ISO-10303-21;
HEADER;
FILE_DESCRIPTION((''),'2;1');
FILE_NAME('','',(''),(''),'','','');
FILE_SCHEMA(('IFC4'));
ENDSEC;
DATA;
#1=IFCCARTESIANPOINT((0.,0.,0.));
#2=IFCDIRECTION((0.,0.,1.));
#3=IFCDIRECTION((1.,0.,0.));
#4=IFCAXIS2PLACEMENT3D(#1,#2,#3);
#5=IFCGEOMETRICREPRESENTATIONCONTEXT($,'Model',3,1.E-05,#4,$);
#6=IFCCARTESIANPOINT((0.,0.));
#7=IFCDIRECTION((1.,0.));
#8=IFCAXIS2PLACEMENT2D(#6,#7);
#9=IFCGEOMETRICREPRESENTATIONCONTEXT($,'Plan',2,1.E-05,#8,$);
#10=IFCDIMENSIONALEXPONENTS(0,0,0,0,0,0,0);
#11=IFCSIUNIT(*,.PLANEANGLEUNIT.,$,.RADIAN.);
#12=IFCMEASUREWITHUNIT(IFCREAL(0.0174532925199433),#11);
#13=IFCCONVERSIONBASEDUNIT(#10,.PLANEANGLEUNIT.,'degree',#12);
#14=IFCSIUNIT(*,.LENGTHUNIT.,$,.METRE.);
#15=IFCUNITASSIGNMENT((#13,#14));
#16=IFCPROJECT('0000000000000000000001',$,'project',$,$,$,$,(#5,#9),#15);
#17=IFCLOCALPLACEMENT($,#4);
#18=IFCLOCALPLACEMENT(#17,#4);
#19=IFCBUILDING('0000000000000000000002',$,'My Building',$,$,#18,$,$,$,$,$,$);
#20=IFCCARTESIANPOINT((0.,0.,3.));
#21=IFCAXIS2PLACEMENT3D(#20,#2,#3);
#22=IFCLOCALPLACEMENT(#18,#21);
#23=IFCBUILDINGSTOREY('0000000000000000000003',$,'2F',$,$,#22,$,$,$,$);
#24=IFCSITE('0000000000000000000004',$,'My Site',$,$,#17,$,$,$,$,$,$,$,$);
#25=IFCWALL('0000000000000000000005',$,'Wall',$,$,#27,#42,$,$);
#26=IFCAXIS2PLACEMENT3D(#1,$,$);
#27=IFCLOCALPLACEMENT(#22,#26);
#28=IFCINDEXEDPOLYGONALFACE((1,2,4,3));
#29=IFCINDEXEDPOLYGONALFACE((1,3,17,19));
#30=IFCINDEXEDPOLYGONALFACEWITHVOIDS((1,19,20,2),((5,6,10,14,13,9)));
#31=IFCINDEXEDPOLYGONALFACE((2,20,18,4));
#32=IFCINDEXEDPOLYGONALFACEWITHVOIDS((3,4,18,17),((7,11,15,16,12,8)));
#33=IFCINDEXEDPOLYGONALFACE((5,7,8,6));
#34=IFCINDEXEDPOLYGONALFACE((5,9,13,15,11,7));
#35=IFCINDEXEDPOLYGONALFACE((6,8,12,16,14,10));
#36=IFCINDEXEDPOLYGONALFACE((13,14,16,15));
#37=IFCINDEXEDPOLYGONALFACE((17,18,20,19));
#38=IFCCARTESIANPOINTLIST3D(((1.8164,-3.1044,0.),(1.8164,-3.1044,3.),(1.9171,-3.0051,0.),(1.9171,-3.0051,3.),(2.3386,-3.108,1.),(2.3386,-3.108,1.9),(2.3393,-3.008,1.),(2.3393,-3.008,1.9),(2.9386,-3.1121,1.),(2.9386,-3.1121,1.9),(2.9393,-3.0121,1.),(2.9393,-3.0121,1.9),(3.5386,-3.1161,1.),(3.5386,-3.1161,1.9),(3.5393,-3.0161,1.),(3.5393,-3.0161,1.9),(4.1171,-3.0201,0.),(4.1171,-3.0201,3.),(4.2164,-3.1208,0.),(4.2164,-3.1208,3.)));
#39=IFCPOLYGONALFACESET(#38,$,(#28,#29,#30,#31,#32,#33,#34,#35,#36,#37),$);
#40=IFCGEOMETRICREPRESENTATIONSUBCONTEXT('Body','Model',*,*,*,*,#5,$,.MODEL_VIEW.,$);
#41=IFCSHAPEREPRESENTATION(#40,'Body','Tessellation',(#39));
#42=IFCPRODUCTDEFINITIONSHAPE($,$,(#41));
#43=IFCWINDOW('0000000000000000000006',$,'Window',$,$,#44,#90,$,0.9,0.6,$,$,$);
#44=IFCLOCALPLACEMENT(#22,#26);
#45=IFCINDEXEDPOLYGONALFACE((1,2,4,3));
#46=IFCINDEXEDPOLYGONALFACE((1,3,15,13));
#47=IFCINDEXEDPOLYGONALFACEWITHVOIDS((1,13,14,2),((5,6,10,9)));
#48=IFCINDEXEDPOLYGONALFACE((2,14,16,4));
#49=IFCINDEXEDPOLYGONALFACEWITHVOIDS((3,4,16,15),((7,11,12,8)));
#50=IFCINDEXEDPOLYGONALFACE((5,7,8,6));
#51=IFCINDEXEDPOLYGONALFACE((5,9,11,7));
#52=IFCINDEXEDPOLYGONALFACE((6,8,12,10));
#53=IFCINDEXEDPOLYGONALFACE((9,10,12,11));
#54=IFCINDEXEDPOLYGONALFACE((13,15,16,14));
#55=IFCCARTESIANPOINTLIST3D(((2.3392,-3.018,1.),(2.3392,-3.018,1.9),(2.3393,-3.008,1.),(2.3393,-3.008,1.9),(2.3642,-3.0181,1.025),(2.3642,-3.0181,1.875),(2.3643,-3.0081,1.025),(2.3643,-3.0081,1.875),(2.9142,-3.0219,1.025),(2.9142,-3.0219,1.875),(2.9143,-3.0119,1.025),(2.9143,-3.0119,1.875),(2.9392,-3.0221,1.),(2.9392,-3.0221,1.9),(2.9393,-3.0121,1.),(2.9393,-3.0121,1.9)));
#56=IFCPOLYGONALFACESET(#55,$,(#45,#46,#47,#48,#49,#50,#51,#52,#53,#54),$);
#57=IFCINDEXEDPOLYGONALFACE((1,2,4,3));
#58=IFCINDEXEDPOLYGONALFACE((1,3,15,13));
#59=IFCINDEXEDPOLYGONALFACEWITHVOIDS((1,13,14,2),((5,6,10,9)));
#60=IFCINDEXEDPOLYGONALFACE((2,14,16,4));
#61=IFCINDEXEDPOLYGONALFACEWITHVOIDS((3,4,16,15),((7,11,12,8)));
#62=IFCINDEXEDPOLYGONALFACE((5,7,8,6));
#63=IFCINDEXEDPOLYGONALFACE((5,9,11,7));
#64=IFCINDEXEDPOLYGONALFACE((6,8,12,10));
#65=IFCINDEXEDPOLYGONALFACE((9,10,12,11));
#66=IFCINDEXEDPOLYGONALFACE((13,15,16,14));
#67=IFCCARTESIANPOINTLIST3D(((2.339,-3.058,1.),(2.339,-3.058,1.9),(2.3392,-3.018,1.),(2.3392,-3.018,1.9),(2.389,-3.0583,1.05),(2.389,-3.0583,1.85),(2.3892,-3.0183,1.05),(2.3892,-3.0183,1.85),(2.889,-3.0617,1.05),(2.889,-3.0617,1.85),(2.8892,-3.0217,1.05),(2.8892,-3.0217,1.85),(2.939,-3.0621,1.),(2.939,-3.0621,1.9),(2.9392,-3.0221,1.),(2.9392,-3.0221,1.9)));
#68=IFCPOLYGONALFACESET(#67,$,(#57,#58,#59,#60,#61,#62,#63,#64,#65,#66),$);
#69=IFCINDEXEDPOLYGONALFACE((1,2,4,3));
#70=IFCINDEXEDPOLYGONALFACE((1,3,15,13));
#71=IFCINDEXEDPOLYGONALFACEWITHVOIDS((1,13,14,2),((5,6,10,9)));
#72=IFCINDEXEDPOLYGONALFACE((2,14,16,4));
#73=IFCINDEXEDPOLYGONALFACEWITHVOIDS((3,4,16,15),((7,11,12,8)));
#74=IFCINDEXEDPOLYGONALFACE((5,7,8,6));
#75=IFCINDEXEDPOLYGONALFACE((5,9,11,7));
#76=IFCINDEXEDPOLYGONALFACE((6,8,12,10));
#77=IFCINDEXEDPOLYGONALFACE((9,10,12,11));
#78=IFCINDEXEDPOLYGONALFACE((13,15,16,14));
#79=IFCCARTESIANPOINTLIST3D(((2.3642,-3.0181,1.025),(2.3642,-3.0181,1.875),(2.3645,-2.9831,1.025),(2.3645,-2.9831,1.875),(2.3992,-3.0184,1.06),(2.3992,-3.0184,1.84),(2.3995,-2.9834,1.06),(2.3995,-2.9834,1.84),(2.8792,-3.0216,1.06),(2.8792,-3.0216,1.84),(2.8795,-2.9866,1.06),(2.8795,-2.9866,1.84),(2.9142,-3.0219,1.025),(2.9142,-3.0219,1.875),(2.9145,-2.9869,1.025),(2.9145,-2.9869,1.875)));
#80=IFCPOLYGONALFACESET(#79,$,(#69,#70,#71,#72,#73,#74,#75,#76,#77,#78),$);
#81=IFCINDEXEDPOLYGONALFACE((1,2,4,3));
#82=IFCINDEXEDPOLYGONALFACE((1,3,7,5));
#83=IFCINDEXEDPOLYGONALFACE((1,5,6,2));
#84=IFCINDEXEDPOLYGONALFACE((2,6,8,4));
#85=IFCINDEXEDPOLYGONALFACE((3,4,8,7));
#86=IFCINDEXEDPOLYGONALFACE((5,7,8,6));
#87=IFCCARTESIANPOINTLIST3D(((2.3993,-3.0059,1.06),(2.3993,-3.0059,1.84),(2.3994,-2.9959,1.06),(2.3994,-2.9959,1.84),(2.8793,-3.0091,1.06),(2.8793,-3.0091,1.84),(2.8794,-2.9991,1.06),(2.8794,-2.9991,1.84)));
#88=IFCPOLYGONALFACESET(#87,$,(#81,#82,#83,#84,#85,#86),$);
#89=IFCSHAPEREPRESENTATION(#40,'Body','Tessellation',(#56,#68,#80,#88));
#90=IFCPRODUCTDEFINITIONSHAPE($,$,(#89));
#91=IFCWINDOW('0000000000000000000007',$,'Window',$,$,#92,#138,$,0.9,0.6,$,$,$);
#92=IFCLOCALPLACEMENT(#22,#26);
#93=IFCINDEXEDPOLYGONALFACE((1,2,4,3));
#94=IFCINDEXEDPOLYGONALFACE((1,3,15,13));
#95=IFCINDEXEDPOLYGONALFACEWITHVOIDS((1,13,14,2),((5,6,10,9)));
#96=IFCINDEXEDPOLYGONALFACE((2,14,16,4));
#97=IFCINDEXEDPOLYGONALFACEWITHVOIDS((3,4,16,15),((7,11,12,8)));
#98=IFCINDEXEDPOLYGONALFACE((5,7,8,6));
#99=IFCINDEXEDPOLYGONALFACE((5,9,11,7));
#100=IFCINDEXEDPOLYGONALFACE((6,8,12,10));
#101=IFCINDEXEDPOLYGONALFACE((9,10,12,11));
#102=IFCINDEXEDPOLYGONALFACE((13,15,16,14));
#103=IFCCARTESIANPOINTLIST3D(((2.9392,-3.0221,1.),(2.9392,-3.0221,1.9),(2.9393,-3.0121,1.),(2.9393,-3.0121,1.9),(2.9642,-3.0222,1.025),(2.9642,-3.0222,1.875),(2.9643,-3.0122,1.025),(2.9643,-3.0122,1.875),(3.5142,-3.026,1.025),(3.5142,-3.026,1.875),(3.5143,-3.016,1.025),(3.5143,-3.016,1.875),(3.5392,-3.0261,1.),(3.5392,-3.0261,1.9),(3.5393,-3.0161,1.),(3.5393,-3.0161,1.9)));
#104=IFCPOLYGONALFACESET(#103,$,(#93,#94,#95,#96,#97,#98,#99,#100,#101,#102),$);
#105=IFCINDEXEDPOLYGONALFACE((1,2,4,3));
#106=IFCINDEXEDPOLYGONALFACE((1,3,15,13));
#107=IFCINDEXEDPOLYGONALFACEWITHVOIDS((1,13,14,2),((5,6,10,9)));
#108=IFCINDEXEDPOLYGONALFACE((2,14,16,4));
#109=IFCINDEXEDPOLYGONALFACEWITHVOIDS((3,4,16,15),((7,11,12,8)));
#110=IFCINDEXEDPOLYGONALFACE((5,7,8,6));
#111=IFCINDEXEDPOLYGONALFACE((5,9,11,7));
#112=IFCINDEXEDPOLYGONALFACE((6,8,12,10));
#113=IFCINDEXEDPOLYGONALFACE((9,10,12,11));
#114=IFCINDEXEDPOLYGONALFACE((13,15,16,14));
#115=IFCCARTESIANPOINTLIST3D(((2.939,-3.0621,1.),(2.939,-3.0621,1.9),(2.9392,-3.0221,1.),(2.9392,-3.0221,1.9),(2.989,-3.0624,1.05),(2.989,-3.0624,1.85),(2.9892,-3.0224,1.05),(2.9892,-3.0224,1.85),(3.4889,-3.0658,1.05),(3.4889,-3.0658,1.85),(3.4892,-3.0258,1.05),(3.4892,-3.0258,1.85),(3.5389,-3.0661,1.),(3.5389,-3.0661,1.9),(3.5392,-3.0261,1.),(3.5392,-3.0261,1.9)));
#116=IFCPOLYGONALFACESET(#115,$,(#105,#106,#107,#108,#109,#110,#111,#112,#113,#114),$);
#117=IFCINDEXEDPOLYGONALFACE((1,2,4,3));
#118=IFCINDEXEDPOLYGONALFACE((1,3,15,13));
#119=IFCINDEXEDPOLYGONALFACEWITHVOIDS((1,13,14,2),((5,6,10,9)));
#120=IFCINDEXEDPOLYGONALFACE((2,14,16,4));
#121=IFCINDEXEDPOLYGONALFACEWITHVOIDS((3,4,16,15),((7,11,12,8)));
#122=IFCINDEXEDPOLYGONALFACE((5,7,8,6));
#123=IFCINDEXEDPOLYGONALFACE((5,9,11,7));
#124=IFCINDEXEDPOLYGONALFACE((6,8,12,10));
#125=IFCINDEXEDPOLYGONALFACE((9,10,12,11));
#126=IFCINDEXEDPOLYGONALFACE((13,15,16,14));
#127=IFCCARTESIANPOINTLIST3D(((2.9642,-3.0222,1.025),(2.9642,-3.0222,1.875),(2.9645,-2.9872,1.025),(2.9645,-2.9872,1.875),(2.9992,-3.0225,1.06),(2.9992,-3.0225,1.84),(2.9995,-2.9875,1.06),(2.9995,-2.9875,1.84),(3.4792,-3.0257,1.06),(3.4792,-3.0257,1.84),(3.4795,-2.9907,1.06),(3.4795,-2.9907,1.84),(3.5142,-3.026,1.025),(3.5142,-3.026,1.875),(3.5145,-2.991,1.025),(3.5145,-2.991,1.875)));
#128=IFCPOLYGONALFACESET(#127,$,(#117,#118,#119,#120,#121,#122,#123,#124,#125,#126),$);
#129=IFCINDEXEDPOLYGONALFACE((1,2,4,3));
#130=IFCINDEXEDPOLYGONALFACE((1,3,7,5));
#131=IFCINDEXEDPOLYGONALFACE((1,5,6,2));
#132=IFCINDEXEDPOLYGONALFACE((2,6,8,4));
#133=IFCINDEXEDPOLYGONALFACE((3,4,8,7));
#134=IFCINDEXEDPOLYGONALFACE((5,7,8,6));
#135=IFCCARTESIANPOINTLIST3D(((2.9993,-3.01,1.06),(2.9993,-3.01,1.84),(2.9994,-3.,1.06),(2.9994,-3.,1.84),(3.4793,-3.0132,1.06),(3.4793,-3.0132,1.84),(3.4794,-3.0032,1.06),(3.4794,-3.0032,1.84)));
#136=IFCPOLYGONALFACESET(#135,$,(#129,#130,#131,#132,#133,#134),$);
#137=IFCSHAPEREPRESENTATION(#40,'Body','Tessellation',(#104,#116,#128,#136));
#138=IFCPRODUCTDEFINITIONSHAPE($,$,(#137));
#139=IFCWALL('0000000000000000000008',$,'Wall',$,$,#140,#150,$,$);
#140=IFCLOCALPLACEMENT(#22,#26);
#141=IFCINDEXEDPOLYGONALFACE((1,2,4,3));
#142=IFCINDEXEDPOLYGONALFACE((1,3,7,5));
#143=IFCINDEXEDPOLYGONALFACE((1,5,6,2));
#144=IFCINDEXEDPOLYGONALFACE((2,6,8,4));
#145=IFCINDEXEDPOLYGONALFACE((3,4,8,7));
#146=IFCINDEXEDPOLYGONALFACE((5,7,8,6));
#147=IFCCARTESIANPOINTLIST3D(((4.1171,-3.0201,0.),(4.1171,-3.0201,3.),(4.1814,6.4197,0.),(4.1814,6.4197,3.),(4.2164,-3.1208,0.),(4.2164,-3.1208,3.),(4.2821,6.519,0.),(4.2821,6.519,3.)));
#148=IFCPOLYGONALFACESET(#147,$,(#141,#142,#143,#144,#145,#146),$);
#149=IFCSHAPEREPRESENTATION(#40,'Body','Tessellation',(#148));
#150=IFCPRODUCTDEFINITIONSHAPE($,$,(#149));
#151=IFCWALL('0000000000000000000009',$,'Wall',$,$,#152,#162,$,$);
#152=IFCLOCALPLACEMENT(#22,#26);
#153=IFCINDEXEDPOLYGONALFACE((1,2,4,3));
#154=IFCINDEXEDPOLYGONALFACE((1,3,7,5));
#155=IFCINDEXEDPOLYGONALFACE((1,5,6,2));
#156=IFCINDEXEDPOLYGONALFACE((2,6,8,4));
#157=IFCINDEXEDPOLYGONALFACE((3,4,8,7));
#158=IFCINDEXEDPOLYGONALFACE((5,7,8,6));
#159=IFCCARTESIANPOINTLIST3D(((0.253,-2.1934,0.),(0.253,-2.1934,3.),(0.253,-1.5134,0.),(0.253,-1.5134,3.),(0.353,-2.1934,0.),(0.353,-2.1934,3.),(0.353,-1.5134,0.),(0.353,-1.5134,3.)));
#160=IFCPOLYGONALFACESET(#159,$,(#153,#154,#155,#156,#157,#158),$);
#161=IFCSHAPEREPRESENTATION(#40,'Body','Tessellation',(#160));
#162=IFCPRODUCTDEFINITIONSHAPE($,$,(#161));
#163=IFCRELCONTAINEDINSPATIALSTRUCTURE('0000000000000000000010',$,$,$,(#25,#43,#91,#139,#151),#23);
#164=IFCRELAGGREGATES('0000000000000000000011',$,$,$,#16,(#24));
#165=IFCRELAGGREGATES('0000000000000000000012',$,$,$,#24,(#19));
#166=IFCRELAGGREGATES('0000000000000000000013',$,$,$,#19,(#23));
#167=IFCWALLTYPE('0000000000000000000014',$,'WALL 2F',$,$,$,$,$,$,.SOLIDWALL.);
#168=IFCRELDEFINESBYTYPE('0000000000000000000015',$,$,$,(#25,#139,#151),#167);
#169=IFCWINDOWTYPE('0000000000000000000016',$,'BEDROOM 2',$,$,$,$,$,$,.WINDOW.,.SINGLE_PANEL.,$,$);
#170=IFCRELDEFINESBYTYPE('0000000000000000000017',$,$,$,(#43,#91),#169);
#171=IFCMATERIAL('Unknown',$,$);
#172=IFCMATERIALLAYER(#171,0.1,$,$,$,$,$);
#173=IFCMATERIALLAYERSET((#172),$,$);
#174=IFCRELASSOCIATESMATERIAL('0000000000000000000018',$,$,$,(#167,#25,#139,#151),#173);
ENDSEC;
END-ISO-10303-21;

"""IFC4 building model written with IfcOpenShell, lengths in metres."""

from ifc_helpers import new_model, entity, si_unit, converted_unit, frame, origin_with_axes, origin_2d_with_axis, place, context, subcontext, project, spatial, line, indexed_curve, outline, extrude, shape, source, transform, mapped, material, layer, layer_set, layer_usage, type_object, type_shapes, element, fill, save


model = new_model("IFC4")

# Units and contexts
model_context = context("Model", 3, precision=1e-05, world=origin_with_axes())
plan_context = context("Plan", 2, precision=1e-05, world=origin_2d_with_axis())
body_context_1 = subcontext(model_context, "Body", "Model", "MODEL_VIEW")
body_context_2 = subcontext(plan_context, "Body", "Plan", "PLAN_VIEW")
ifc_project = project(units=[converted_unit("PLANEANGLEUNIT", "degree", entity("IfcReal", 0.0174532925199433), si_unit("PLANEANGLEUNIT", "RADIAN"), dimensions=[0, 0, 0, 0, 0, 0, 0]), si_unit("LENGTHUNIT", "METRE")], contexts=[model_context, plan_context])

# Site, building, storey
site_placement = place(None, origin_with_axes())
site = spatial("IfcSite", under=ifc_project, at=site_placement, Name="My Site")
building_placement = place(site_placement, origin_with_axes())
building = spatial("IfcBuilding", under=site, at=building_placement, Name="My Building")
storey_placement = place(building_placement, frame((0.0, 0.0, 3.0), z_axis=(0.0, 0.0, 1.0), x_axis=(1.0, 0.0, 0.0)))
storey = spatial("IfcBuildingStorey", under=building, at=storey_placement, Name="2F")

# Shared definitions
ifc_material = material(Name="Unknown")

# Shared definitions
ifc_layer = layer(ifc_material, 0.1)
ifc_layer_set = layer_set([ifc_layer])
wall_type = type_object("IfcWallType", Name="WALL 2F", PredefinedType="SOLIDWALL", material=ifc_layer_set)

# Wall, openings, windows
ifc_layer_usage_1 = layer_usage(ifc_layer_set, "AXIS2", "POSITIVE", 0.0)
wall_1_placement = place(storey_placement, frame((1.8164, -3.1044, 0.0), z_axis=(0.0, 0.0, 1.0), x_axis=(0.999977, -0.006814, 0.0)))
wall_1 = element("IfcWall", 1, at=wall_1_placement, inside=storey, type_object=wall_type, material=ifc_layer_usage_1, Name="Wall", context=body_context_1, shape_type="SweptSolid", body=[
    extrude(outline(indexed_curve([(0.0, 0.0), (0.1, 0.1), (2.3, 0.1), (2.4, 0.0)], segments=[line(1, 2, 3, 4, 1)])), origin_with_axes(), (0.0, 0.0, 1.0), 3.0),
])
shared_shape_1 = source(origin_with_axes(), body_context_1, "Body", "SweptSolid", [
    extrude(outline(indexed_curve([(0.0, 0.0), (0.6, 0.0), (0.6, 0.9), (0.0, 0.9)], segments=[line(1, 2, 3, 4, 1)])), frame((0.0, -0.6, 0.0), z_axis=(0.0, -1.0, 0.0), x_axis=(1.0, 0.0, 0.0)), (0.0, 0.0, -1.0), 1.2),
])
opening_1_placement = place(wall_1_placement, frame((0.5222, 0.0, 1.0), z_axis=(0.0, 0.0, 1.0), x_axis=(1.0, 0.0, 0.0)))
opening_1 = element("IfcOpeningElement", 2, at=opening_1_placement, cuts=wall_1, PredefinedType="OPENING", context=body_context_1, shape_type="MappedRepresentation", body=[
    mapped(shared_shape_1, transform((0.0, 0.0, 0.0), x_axis=(1.0, 0.0, 0.0), y_axis=(0.0, 1.0, 0.0), z_axis=(0.0, 0.0, 1.0), scale=1.0)),
])
opening_2_placement = place(wall_1_placement, frame((1.1222, 0.0, 1.0), z_axis=(0.0, 0.0, 1.0), x_axis=(1.0, 0.0, 0.0)))
opening_2 = element("IfcOpeningElement", 3, at=opening_2_placement, cuts=wall_1, PredefinedType="OPENING", context=body_context_1, shape_type="MappedRepresentation", body=[
    mapped(shared_shape_1, transform((0.0, 0.0, 0.0), x_axis=(1.0, 0.0, 0.0), y_axis=(0.0, 1.0, 0.0), z_axis=(0.0, 0.0, 1.0), scale=1.0)),
])
window_type = type_object("IfcWindowType", Name="BEDROOM 2", PartitioningType="SINGLE_PANEL", PredefinedType="WINDOW")
shared_shape_2 = source(origin_with_axes(), body_context_1, "Body", "SweptSolid", [
    extrude(outline(indexed_curve([(0.0, 0.0), (0.6, 0.0), (0.6, 0.9), (0.0, 0.9)], segments=[line(1, 2, 3, 4, 1)]), holes=[indexed_curve([(0.025, 0.025), (0.575, 0.025), (0.575, 0.875), (0.025, 0.875)], segments=[line(1, 2, 3, 4, 1)])]), frame((0.0, 0.09, 0.0), z_axis=(0.0, -1.0, 0.0), x_axis=(1.0, 0.0, 0.0)), (0.0, 0.0, -1.0), 0.01),
    extrude(outline(indexed_curve([(0.0, 0.0), (0.6, 0.0), (0.6, 0.9), (0.0, 0.9)], segments=[line(1, 2, 3, 4, 1)]), holes=[indexed_curve([(0.05, 0.05), (0.55, 0.05), (0.55, 0.85), (0.05, 0.85)], segments=[line(1, 2, 3, 4, 1)])]), frame((0.0, 0.05, 0.0), z_axis=(0.0, -1.0, 0.0), x_axis=(1.0, 0.0, 0.0)), (0.0, 0.0, -1.0), 0.04),
    extrude(outline(indexed_curve([(0.0, 0.0), (0.55, 0.0), (0.55, 0.85), (0.0, 0.85)], segments=[line(1, 2, 3, 4, 1)]), holes=[indexed_curve([(0.035, 0.035), (0.515, 0.035), (0.515, 0.815), (0.035, 0.815)], segments=[line(1, 2, 3, 4, 1)])]), frame((0.025, 0.09, 0.025), z_axis=(0.0, -1.0, 0.0), x_axis=(1.0, 0.0, 0.0)), (0.0, 0.0, -1.0), 0.035),
    extrude(outline(indexed_curve([(0.035, 0.035), (0.515, 0.035), (0.515, 0.815), (0.035, 0.815)], segments=[line(1, 2, 3, 4, 1)])), frame((0.025, 0.1025, 0.025), z_axis=(0.0, -1.0, 0.0), x_axis=(1.0, 0.0, 0.0)), (0.0, 0.0, -1.0), 0.01),
])
shared_shape_3 = source(origin_with_axes(), body_context_2, "Body", "Curve2D", [
    entity("IfcIndexedPolyCurve", entity("IfcCartesianPointList2D", [[0.05, 0.05], [0.55, 0.05]])),
    entity("IfcIndexedPolyCurve", entity("IfcCartesianPointList2D", [[0.0, 0.1], [0.025, 0.1], [0.025, 0.09], [0.05, 0.09], [0.05, 0.05], [0.0, 0.05]]), [entity("IfcLineIndex", [1, 2, 3, 4, 5, 6, 1])]),
    entity("IfcIndexedPolyCurve", entity("IfcCartesianPointList2D", [[0.6, 0.1], [0.575, 0.1], [0.575, 0.09], [0.55, 0.09], [0.55, 0.05], [0.6, 0.05]]), [entity("IfcLineIndex", [1, 2, 3, 4, 5, 6, 1])]),
    entity("IfcIndexedPolyCurve", entity("IfcCartesianPointList2D", [[0.025, 0.09], [0.06, 0.09], [0.06, 0.125], [0.025, 0.125]]), [entity("IfcLineIndex", [1, 2, 3, 4, 1])]),
    entity("IfcIndexedPolyCurve", entity("IfcCartesianPointList2D", [[0.575, 0.09], [0.54, 0.09], [0.54, 0.125], [0.575, 0.125]]), [entity("IfcLineIndex", [1, 2, 3, 4, 1])]),
    entity("IfcIndexedPolyCurve", entity("IfcCartesianPointList2D", [[0.06, 0.09], [0.54, 0.09]])),
    entity("IfcIndexedPolyCurve", entity("IfcCartesianPointList2D", [[0.06, 0.125], [0.54, 0.125]])),
    entity("IfcIndexedPolyCurve", entity("IfcCartesianPointList2D", [[0.06, 0.1075], [0.54, 0.1075]])),
])
type_shapes(window_type, [shared_shape_2, shared_shape_3])
window_1_placement = place(opening_1_placement, frame((0.0, 0.0, 0.0), z_axis=(0.0, 0.0, 1.0), x_axis=(1.0, 0.0, 0.0)))
window_1 = element("IfcWindow", 4, at=window_1_placement, inside=storey, type_object=window_type, Name="Window", OverallHeight=0.9, OverallWidth=0.6, shapes=[
    shape(body_context_1, "Body", "MappedRepresentation", [mapped(shared_shape_2, transform((0.0, 0.0, 0.0), x_axis=(1.0, 0.0, 0.0), y_axis=(0.0, 1.0, 0.0), z_axis=(0.0, 0.0, 1.0), scale=1.0))]),
    shape(body_context_2, "Body", "MappedRepresentation", [mapped(shared_shape_3, transform((0.0, 0.0, 0.0), x_axis=(1.0, 0.0, 0.0), y_axis=(0.0, 1.0, 0.0), z_axis=(0.0, 0.0, 1.0), scale=1.0))]),
])
fill(opening_1, window_1)
window_2_placement = place(opening_2_placement, frame((0.0, 0.0, 0.0), z_axis=(0.0, 0.0, 1.0), x_axis=(1.0, 0.0, 0.0)))
window_2 = element("IfcWindow", 5, at=window_2_placement, inside=storey, type_object=window_type, Name="Window", OverallHeight=0.9, OverallWidth=0.6, shapes=[
    shape(body_context_1, "Body", "MappedRepresentation", [mapped(shared_shape_2, transform((0.0, 0.0, 0.0), x_axis=(1.0, 0.0, 0.0), y_axis=(0.0, 1.0, 0.0), z_axis=(0.0, 0.0, 1.0), scale=1.0))]),
    shape(body_context_2, "Body", "MappedRepresentation", [mapped(shared_shape_3, transform((0.0, 0.0, 0.0), x_axis=(1.0, 0.0, 0.0), y_axis=(0.0, 1.0, 0.0), z_axis=(0.0, 0.0, 1.0), scale=1.0))]),
])
fill(opening_2, window_2)

# Walls
ifc_layer_usage_2 = layer_usage(ifc_layer_set, "AXIS2", "POSITIVE", 0.0)
wall_2_placement = place(storey_placement, frame((4.2164, -3.1208, 0.0), z_axis=(0.0, 0.0, 1.0), x_axis=(0.006815, 0.999977, 0.0)))
element("IfcWall", 6, at=wall_2_placement, inside=storey, type_object=wall_type, material=ifc_layer_usage_2, Name="Wall", context=body_context_1, shape_type="SweptSolid", body=[
    extrude(outline(indexed_curve([(0.0, 0.0), (0.1, 0.1), (9.54, 0.1), (9.64, 0.0)], segments=[line(1, 2, 3, 4, 1)])), origin_with_axes(), (0.0, 0.0, 1.0), 3.0),
])
ifc_layer_usage_3 = layer_usage(ifc_layer_set, "AXIS2", "POSITIVE", 0.0)
wall_3_placement = place(storey_placement, frame((0.253, -1.5134, 0.0), z_axis=(0.0, 0.0, 1.0), x_axis=(0.0, -1.0, 0.0)))
element("IfcWall", 7, at=wall_3_placement, inside=storey, type_object=wall_type, material=ifc_layer_usage_3, Name="Wall", context=body_context_1, shape_type="SweptSolid", body=[
    extrude(outline(indexed_curve([(0.0, 0.0), (0.0, 0.1), (0.68, 0.1), (0.68, 0.0)], segments=[line(1, 2, 3, 4, 1)])), origin_with_axes(), (0.0, 0.0, 1.0), 3.0),
])

save(model, "model.ifc")
